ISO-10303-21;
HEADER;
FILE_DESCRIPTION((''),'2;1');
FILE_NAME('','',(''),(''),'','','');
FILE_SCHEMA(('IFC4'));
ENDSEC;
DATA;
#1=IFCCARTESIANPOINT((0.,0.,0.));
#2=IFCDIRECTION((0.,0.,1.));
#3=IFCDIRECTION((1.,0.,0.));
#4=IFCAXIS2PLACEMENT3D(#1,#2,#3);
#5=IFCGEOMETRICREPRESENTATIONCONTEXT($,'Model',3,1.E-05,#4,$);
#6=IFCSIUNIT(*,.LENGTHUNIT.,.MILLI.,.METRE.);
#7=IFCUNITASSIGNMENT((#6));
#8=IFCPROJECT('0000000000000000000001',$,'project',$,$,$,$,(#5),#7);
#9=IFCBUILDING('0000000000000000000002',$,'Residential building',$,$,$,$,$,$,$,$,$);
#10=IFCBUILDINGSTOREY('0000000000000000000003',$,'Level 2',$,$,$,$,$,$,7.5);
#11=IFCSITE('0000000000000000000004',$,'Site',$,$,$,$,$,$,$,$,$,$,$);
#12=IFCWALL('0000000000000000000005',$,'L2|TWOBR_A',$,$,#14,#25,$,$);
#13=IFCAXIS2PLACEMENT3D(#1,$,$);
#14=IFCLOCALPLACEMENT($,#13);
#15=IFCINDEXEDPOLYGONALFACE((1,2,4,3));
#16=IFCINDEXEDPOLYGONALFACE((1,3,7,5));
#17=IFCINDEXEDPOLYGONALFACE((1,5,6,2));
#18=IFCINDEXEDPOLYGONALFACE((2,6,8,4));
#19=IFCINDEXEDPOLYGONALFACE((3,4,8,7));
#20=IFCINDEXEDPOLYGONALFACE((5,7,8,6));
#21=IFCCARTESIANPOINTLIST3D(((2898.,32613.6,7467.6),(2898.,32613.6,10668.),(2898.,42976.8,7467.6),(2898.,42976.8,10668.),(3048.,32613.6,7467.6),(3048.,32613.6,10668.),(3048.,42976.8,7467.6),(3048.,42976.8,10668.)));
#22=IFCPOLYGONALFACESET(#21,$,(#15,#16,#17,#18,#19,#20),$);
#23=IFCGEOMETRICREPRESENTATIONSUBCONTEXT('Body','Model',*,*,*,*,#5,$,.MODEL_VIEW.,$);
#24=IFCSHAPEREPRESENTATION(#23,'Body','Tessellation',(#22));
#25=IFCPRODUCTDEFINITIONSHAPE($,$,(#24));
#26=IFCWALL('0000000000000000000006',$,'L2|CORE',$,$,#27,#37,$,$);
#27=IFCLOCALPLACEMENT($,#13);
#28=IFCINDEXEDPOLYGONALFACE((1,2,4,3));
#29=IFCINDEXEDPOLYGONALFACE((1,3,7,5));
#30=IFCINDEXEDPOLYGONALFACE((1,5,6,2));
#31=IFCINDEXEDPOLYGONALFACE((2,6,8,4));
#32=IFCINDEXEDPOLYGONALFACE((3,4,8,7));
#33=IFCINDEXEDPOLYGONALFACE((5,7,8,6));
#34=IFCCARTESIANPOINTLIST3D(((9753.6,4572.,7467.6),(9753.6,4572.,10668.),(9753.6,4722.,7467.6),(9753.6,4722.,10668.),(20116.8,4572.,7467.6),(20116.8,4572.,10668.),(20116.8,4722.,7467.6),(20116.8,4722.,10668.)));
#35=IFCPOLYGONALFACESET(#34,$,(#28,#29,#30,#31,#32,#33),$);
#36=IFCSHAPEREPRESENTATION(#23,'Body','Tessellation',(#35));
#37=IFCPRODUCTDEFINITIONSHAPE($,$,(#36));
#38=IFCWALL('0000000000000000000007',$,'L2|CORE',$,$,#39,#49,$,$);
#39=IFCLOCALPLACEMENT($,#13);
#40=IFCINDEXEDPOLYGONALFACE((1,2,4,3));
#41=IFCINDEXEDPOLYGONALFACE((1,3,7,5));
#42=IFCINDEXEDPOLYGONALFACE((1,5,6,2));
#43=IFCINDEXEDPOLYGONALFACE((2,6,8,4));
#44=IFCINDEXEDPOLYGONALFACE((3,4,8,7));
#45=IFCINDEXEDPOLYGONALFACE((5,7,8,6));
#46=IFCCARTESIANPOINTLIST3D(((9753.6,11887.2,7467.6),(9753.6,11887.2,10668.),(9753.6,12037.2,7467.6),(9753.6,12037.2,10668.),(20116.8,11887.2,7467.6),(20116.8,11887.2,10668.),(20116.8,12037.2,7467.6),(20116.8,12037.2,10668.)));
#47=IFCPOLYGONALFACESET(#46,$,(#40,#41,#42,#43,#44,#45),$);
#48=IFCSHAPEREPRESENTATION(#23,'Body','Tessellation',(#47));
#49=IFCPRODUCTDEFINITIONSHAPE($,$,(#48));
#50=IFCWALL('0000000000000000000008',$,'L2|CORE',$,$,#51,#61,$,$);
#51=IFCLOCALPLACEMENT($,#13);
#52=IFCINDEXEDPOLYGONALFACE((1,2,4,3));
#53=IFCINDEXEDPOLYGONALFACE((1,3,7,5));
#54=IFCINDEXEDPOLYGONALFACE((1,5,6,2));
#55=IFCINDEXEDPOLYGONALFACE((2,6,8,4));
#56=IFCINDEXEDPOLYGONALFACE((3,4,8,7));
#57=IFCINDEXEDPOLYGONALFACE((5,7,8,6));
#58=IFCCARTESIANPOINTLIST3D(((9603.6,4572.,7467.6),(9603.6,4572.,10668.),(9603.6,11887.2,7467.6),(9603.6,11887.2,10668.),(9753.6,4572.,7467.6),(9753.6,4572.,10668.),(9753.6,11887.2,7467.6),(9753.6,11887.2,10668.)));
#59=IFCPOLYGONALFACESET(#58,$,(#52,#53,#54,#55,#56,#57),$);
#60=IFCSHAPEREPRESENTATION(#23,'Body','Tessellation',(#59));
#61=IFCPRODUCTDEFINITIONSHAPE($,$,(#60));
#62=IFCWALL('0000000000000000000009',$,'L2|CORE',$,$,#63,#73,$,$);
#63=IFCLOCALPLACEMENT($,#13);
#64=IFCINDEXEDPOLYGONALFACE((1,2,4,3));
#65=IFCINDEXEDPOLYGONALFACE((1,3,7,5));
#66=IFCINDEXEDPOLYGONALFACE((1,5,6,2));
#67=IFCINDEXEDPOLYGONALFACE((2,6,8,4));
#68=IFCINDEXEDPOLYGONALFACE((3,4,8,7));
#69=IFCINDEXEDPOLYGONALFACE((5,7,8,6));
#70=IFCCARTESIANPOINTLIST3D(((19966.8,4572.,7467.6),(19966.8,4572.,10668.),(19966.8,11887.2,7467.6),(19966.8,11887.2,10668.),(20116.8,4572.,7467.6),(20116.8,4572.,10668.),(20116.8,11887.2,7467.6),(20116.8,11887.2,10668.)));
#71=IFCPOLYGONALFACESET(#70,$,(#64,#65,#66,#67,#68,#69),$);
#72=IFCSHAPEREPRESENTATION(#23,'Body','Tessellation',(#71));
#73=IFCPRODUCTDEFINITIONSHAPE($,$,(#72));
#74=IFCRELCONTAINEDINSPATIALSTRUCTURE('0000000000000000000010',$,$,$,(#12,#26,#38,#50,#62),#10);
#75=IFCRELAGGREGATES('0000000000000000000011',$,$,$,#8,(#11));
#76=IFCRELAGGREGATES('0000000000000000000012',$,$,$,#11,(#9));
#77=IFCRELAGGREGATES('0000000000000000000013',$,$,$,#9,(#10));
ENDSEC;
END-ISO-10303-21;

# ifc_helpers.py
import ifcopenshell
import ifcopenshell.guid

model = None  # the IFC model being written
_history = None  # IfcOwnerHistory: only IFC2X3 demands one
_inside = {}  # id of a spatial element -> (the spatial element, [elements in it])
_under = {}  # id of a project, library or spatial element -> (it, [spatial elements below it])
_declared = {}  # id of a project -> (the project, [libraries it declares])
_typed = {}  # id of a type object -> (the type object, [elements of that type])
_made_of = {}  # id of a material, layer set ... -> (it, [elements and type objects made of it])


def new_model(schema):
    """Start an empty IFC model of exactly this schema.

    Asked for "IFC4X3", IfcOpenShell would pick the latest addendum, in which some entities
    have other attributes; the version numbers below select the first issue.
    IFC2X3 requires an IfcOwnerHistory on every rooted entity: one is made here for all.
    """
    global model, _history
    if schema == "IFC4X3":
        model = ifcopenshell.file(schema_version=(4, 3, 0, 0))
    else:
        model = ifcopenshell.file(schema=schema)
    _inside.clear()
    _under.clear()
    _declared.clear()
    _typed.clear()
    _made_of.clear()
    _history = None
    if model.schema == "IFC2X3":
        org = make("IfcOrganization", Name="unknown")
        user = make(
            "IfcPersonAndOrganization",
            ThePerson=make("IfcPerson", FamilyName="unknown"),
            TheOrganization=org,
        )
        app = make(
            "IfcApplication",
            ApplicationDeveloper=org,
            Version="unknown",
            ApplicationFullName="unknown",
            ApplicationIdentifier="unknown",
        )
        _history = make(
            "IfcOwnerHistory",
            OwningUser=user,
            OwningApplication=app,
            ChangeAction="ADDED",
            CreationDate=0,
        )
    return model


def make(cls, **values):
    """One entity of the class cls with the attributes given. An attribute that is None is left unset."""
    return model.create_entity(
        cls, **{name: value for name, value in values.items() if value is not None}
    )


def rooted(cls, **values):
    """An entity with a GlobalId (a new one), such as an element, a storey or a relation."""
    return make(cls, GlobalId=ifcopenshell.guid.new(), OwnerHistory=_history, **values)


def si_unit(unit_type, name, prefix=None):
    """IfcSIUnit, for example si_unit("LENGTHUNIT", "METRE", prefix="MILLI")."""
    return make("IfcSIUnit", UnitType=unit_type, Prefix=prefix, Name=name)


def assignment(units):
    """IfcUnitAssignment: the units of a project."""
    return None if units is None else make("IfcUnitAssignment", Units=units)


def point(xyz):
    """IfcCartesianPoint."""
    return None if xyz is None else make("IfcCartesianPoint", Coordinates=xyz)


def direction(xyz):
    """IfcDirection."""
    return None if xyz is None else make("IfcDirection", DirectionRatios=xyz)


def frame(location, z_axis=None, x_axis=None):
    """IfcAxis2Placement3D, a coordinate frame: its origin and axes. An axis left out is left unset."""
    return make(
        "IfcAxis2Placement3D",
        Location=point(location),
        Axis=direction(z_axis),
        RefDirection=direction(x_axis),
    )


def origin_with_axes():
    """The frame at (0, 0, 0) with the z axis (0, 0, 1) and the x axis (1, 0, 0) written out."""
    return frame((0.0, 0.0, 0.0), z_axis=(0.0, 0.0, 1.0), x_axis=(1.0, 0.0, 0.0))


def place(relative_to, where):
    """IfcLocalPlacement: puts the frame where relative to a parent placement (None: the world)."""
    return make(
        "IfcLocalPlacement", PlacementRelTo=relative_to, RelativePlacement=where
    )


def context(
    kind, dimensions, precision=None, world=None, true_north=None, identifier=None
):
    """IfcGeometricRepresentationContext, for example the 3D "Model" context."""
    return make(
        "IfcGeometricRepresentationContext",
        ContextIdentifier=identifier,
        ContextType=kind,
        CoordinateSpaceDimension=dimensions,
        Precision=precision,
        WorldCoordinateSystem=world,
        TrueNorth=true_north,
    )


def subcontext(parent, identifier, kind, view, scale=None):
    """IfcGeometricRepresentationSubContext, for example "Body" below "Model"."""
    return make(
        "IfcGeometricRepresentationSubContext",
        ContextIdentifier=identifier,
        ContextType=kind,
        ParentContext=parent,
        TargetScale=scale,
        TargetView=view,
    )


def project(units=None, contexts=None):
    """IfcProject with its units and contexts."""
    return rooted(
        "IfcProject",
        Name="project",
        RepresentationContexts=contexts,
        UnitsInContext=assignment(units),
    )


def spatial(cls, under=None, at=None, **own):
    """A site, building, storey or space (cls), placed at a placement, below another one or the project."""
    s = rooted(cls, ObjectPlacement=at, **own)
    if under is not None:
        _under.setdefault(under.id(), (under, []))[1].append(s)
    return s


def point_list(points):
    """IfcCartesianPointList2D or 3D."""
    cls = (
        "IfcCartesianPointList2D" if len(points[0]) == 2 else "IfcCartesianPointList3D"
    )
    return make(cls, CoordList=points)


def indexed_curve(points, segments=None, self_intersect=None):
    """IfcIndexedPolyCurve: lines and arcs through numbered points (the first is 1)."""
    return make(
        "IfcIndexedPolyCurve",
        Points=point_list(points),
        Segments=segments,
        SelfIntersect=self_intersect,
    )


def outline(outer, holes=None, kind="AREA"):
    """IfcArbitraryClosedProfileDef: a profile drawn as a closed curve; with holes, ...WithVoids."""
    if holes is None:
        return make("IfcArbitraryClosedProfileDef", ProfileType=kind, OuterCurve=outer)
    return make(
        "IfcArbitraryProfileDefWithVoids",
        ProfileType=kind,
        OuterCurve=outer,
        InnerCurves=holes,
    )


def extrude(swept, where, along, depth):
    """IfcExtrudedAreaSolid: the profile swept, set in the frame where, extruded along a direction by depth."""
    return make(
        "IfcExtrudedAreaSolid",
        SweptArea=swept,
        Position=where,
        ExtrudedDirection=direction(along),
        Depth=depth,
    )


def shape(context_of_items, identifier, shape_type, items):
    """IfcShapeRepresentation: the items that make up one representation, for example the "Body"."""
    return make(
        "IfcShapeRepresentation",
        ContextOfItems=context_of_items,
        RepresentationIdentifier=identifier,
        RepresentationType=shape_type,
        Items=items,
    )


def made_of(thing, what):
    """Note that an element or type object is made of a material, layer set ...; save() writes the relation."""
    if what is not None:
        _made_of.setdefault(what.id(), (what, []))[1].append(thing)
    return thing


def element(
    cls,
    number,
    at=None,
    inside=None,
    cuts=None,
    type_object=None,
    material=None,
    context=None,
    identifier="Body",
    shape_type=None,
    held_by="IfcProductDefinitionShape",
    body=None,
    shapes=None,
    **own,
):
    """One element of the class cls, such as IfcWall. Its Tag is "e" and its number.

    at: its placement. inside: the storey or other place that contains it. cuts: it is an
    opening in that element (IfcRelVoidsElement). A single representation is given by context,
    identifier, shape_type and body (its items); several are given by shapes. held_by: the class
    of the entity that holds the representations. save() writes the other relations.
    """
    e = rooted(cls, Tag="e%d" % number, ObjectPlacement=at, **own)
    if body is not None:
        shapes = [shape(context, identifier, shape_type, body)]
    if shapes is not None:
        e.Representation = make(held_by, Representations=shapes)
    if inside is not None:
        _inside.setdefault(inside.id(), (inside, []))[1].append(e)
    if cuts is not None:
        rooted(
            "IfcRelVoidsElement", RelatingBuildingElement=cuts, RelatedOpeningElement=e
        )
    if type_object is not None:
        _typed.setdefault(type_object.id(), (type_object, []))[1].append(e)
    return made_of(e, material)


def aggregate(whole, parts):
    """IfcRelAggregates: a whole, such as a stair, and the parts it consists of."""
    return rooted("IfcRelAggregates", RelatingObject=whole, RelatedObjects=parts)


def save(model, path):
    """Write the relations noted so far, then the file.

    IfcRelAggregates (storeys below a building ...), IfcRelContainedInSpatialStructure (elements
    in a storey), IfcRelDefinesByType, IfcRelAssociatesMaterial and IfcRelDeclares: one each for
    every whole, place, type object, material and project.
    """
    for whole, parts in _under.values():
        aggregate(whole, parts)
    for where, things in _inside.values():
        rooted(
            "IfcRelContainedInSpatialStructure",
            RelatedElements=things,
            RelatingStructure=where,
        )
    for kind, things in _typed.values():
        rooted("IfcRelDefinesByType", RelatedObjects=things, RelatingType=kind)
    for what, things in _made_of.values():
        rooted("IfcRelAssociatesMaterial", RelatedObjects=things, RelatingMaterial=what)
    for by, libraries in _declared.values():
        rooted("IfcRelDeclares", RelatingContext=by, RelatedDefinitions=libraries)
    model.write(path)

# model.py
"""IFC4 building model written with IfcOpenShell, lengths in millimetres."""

from ifc_helpers import new_model, si_unit, frame, origin_with_axes, place, context, subcontext, project, spatial, indexed_curve, outline, extrude, element, save


model = new_model("IFC4")

# Units and contexts
model_context = context("Model", 3, precision=1e-05, world=origin_with_axes())
body_context = subcontext(model_context, "Body", "Model", "MODEL_VIEW")
ifc_project = project(units=[si_unit("LENGTHUNIT", "METRE", prefix="MILLI")], contexts=[model_context])

# Site, building, storey
site = spatial("IfcSite", under=ifc_project, Name="Site")
building = spatial("IfcBuilding", under=site, Name="Residential building")
storey = spatial("IfcBuildingStorey", under=building, Name="Level 2", Elevation=7.5)

# Walls
for number, where, z_axis, x_axis, name in (
    (1, (3048.0, 32613.6, 7467.6), (0.0, 0.0, 1.0), (0.0, 1.0, 0.0), "L2|TWOBR_A"),
    (2, (9753.6, 4572.0, 7467.6), (0.0, 0.0, 1.0), (1.0, 0.0, 0.0), "L2|CORE"),
    (3, (9753.6, 11887.2, 7467.6), (0.0, 0.0, 1.0), (1.0, 0.0, 0.0), "L2|CORE"),
):
    element("IfcWall", number, at=place(None, frame(where, z_axis=z_axis, x_axis=x_axis)), inside=storey, Name=name, context=body_context, shape_type="SweptSolid", body=[
        extrude(outline(indexed_curve([(0.0, 0.0), (0.0, 150.0), (10363.2, 150.0), (10363.2, 0.0), (0.0, 0.0)], self_intersect=False)), origin_with_axes(), (0.0, 0.0, 1.0), 3200.4),
    ])
for number, where, z_axis, x_axis, name in (
    (4, (9753.6, 4572.0, 7467.6), (0.0, 0.0, 1.0), (0.0, 1.0, 0.0), "L2|CORE"),
    (5, (20116.8, 4572.0, 7467.6), (0.0, 0.0, 1.0), (0.0, 1.0, 0.0), "L2|CORE"),
):
    element("IfcWall", number, at=place(None, frame(where, z_axis=z_axis, x_axis=x_axis)), inside=storey, Name=name, context=body_context, shape_type="SweptSolid", body=[
        extrude(outline(indexed_curve([(0.0, 0.0), (0.0, 150.0), (7315.2, 150.0), (7315.2, 0.0), (0.0, 0.0)], self_intersect=False)), origin_with_axes(), (0.0, 0.0, 1.0), 3200.4),
    ])

save(model, "model.ifc")
